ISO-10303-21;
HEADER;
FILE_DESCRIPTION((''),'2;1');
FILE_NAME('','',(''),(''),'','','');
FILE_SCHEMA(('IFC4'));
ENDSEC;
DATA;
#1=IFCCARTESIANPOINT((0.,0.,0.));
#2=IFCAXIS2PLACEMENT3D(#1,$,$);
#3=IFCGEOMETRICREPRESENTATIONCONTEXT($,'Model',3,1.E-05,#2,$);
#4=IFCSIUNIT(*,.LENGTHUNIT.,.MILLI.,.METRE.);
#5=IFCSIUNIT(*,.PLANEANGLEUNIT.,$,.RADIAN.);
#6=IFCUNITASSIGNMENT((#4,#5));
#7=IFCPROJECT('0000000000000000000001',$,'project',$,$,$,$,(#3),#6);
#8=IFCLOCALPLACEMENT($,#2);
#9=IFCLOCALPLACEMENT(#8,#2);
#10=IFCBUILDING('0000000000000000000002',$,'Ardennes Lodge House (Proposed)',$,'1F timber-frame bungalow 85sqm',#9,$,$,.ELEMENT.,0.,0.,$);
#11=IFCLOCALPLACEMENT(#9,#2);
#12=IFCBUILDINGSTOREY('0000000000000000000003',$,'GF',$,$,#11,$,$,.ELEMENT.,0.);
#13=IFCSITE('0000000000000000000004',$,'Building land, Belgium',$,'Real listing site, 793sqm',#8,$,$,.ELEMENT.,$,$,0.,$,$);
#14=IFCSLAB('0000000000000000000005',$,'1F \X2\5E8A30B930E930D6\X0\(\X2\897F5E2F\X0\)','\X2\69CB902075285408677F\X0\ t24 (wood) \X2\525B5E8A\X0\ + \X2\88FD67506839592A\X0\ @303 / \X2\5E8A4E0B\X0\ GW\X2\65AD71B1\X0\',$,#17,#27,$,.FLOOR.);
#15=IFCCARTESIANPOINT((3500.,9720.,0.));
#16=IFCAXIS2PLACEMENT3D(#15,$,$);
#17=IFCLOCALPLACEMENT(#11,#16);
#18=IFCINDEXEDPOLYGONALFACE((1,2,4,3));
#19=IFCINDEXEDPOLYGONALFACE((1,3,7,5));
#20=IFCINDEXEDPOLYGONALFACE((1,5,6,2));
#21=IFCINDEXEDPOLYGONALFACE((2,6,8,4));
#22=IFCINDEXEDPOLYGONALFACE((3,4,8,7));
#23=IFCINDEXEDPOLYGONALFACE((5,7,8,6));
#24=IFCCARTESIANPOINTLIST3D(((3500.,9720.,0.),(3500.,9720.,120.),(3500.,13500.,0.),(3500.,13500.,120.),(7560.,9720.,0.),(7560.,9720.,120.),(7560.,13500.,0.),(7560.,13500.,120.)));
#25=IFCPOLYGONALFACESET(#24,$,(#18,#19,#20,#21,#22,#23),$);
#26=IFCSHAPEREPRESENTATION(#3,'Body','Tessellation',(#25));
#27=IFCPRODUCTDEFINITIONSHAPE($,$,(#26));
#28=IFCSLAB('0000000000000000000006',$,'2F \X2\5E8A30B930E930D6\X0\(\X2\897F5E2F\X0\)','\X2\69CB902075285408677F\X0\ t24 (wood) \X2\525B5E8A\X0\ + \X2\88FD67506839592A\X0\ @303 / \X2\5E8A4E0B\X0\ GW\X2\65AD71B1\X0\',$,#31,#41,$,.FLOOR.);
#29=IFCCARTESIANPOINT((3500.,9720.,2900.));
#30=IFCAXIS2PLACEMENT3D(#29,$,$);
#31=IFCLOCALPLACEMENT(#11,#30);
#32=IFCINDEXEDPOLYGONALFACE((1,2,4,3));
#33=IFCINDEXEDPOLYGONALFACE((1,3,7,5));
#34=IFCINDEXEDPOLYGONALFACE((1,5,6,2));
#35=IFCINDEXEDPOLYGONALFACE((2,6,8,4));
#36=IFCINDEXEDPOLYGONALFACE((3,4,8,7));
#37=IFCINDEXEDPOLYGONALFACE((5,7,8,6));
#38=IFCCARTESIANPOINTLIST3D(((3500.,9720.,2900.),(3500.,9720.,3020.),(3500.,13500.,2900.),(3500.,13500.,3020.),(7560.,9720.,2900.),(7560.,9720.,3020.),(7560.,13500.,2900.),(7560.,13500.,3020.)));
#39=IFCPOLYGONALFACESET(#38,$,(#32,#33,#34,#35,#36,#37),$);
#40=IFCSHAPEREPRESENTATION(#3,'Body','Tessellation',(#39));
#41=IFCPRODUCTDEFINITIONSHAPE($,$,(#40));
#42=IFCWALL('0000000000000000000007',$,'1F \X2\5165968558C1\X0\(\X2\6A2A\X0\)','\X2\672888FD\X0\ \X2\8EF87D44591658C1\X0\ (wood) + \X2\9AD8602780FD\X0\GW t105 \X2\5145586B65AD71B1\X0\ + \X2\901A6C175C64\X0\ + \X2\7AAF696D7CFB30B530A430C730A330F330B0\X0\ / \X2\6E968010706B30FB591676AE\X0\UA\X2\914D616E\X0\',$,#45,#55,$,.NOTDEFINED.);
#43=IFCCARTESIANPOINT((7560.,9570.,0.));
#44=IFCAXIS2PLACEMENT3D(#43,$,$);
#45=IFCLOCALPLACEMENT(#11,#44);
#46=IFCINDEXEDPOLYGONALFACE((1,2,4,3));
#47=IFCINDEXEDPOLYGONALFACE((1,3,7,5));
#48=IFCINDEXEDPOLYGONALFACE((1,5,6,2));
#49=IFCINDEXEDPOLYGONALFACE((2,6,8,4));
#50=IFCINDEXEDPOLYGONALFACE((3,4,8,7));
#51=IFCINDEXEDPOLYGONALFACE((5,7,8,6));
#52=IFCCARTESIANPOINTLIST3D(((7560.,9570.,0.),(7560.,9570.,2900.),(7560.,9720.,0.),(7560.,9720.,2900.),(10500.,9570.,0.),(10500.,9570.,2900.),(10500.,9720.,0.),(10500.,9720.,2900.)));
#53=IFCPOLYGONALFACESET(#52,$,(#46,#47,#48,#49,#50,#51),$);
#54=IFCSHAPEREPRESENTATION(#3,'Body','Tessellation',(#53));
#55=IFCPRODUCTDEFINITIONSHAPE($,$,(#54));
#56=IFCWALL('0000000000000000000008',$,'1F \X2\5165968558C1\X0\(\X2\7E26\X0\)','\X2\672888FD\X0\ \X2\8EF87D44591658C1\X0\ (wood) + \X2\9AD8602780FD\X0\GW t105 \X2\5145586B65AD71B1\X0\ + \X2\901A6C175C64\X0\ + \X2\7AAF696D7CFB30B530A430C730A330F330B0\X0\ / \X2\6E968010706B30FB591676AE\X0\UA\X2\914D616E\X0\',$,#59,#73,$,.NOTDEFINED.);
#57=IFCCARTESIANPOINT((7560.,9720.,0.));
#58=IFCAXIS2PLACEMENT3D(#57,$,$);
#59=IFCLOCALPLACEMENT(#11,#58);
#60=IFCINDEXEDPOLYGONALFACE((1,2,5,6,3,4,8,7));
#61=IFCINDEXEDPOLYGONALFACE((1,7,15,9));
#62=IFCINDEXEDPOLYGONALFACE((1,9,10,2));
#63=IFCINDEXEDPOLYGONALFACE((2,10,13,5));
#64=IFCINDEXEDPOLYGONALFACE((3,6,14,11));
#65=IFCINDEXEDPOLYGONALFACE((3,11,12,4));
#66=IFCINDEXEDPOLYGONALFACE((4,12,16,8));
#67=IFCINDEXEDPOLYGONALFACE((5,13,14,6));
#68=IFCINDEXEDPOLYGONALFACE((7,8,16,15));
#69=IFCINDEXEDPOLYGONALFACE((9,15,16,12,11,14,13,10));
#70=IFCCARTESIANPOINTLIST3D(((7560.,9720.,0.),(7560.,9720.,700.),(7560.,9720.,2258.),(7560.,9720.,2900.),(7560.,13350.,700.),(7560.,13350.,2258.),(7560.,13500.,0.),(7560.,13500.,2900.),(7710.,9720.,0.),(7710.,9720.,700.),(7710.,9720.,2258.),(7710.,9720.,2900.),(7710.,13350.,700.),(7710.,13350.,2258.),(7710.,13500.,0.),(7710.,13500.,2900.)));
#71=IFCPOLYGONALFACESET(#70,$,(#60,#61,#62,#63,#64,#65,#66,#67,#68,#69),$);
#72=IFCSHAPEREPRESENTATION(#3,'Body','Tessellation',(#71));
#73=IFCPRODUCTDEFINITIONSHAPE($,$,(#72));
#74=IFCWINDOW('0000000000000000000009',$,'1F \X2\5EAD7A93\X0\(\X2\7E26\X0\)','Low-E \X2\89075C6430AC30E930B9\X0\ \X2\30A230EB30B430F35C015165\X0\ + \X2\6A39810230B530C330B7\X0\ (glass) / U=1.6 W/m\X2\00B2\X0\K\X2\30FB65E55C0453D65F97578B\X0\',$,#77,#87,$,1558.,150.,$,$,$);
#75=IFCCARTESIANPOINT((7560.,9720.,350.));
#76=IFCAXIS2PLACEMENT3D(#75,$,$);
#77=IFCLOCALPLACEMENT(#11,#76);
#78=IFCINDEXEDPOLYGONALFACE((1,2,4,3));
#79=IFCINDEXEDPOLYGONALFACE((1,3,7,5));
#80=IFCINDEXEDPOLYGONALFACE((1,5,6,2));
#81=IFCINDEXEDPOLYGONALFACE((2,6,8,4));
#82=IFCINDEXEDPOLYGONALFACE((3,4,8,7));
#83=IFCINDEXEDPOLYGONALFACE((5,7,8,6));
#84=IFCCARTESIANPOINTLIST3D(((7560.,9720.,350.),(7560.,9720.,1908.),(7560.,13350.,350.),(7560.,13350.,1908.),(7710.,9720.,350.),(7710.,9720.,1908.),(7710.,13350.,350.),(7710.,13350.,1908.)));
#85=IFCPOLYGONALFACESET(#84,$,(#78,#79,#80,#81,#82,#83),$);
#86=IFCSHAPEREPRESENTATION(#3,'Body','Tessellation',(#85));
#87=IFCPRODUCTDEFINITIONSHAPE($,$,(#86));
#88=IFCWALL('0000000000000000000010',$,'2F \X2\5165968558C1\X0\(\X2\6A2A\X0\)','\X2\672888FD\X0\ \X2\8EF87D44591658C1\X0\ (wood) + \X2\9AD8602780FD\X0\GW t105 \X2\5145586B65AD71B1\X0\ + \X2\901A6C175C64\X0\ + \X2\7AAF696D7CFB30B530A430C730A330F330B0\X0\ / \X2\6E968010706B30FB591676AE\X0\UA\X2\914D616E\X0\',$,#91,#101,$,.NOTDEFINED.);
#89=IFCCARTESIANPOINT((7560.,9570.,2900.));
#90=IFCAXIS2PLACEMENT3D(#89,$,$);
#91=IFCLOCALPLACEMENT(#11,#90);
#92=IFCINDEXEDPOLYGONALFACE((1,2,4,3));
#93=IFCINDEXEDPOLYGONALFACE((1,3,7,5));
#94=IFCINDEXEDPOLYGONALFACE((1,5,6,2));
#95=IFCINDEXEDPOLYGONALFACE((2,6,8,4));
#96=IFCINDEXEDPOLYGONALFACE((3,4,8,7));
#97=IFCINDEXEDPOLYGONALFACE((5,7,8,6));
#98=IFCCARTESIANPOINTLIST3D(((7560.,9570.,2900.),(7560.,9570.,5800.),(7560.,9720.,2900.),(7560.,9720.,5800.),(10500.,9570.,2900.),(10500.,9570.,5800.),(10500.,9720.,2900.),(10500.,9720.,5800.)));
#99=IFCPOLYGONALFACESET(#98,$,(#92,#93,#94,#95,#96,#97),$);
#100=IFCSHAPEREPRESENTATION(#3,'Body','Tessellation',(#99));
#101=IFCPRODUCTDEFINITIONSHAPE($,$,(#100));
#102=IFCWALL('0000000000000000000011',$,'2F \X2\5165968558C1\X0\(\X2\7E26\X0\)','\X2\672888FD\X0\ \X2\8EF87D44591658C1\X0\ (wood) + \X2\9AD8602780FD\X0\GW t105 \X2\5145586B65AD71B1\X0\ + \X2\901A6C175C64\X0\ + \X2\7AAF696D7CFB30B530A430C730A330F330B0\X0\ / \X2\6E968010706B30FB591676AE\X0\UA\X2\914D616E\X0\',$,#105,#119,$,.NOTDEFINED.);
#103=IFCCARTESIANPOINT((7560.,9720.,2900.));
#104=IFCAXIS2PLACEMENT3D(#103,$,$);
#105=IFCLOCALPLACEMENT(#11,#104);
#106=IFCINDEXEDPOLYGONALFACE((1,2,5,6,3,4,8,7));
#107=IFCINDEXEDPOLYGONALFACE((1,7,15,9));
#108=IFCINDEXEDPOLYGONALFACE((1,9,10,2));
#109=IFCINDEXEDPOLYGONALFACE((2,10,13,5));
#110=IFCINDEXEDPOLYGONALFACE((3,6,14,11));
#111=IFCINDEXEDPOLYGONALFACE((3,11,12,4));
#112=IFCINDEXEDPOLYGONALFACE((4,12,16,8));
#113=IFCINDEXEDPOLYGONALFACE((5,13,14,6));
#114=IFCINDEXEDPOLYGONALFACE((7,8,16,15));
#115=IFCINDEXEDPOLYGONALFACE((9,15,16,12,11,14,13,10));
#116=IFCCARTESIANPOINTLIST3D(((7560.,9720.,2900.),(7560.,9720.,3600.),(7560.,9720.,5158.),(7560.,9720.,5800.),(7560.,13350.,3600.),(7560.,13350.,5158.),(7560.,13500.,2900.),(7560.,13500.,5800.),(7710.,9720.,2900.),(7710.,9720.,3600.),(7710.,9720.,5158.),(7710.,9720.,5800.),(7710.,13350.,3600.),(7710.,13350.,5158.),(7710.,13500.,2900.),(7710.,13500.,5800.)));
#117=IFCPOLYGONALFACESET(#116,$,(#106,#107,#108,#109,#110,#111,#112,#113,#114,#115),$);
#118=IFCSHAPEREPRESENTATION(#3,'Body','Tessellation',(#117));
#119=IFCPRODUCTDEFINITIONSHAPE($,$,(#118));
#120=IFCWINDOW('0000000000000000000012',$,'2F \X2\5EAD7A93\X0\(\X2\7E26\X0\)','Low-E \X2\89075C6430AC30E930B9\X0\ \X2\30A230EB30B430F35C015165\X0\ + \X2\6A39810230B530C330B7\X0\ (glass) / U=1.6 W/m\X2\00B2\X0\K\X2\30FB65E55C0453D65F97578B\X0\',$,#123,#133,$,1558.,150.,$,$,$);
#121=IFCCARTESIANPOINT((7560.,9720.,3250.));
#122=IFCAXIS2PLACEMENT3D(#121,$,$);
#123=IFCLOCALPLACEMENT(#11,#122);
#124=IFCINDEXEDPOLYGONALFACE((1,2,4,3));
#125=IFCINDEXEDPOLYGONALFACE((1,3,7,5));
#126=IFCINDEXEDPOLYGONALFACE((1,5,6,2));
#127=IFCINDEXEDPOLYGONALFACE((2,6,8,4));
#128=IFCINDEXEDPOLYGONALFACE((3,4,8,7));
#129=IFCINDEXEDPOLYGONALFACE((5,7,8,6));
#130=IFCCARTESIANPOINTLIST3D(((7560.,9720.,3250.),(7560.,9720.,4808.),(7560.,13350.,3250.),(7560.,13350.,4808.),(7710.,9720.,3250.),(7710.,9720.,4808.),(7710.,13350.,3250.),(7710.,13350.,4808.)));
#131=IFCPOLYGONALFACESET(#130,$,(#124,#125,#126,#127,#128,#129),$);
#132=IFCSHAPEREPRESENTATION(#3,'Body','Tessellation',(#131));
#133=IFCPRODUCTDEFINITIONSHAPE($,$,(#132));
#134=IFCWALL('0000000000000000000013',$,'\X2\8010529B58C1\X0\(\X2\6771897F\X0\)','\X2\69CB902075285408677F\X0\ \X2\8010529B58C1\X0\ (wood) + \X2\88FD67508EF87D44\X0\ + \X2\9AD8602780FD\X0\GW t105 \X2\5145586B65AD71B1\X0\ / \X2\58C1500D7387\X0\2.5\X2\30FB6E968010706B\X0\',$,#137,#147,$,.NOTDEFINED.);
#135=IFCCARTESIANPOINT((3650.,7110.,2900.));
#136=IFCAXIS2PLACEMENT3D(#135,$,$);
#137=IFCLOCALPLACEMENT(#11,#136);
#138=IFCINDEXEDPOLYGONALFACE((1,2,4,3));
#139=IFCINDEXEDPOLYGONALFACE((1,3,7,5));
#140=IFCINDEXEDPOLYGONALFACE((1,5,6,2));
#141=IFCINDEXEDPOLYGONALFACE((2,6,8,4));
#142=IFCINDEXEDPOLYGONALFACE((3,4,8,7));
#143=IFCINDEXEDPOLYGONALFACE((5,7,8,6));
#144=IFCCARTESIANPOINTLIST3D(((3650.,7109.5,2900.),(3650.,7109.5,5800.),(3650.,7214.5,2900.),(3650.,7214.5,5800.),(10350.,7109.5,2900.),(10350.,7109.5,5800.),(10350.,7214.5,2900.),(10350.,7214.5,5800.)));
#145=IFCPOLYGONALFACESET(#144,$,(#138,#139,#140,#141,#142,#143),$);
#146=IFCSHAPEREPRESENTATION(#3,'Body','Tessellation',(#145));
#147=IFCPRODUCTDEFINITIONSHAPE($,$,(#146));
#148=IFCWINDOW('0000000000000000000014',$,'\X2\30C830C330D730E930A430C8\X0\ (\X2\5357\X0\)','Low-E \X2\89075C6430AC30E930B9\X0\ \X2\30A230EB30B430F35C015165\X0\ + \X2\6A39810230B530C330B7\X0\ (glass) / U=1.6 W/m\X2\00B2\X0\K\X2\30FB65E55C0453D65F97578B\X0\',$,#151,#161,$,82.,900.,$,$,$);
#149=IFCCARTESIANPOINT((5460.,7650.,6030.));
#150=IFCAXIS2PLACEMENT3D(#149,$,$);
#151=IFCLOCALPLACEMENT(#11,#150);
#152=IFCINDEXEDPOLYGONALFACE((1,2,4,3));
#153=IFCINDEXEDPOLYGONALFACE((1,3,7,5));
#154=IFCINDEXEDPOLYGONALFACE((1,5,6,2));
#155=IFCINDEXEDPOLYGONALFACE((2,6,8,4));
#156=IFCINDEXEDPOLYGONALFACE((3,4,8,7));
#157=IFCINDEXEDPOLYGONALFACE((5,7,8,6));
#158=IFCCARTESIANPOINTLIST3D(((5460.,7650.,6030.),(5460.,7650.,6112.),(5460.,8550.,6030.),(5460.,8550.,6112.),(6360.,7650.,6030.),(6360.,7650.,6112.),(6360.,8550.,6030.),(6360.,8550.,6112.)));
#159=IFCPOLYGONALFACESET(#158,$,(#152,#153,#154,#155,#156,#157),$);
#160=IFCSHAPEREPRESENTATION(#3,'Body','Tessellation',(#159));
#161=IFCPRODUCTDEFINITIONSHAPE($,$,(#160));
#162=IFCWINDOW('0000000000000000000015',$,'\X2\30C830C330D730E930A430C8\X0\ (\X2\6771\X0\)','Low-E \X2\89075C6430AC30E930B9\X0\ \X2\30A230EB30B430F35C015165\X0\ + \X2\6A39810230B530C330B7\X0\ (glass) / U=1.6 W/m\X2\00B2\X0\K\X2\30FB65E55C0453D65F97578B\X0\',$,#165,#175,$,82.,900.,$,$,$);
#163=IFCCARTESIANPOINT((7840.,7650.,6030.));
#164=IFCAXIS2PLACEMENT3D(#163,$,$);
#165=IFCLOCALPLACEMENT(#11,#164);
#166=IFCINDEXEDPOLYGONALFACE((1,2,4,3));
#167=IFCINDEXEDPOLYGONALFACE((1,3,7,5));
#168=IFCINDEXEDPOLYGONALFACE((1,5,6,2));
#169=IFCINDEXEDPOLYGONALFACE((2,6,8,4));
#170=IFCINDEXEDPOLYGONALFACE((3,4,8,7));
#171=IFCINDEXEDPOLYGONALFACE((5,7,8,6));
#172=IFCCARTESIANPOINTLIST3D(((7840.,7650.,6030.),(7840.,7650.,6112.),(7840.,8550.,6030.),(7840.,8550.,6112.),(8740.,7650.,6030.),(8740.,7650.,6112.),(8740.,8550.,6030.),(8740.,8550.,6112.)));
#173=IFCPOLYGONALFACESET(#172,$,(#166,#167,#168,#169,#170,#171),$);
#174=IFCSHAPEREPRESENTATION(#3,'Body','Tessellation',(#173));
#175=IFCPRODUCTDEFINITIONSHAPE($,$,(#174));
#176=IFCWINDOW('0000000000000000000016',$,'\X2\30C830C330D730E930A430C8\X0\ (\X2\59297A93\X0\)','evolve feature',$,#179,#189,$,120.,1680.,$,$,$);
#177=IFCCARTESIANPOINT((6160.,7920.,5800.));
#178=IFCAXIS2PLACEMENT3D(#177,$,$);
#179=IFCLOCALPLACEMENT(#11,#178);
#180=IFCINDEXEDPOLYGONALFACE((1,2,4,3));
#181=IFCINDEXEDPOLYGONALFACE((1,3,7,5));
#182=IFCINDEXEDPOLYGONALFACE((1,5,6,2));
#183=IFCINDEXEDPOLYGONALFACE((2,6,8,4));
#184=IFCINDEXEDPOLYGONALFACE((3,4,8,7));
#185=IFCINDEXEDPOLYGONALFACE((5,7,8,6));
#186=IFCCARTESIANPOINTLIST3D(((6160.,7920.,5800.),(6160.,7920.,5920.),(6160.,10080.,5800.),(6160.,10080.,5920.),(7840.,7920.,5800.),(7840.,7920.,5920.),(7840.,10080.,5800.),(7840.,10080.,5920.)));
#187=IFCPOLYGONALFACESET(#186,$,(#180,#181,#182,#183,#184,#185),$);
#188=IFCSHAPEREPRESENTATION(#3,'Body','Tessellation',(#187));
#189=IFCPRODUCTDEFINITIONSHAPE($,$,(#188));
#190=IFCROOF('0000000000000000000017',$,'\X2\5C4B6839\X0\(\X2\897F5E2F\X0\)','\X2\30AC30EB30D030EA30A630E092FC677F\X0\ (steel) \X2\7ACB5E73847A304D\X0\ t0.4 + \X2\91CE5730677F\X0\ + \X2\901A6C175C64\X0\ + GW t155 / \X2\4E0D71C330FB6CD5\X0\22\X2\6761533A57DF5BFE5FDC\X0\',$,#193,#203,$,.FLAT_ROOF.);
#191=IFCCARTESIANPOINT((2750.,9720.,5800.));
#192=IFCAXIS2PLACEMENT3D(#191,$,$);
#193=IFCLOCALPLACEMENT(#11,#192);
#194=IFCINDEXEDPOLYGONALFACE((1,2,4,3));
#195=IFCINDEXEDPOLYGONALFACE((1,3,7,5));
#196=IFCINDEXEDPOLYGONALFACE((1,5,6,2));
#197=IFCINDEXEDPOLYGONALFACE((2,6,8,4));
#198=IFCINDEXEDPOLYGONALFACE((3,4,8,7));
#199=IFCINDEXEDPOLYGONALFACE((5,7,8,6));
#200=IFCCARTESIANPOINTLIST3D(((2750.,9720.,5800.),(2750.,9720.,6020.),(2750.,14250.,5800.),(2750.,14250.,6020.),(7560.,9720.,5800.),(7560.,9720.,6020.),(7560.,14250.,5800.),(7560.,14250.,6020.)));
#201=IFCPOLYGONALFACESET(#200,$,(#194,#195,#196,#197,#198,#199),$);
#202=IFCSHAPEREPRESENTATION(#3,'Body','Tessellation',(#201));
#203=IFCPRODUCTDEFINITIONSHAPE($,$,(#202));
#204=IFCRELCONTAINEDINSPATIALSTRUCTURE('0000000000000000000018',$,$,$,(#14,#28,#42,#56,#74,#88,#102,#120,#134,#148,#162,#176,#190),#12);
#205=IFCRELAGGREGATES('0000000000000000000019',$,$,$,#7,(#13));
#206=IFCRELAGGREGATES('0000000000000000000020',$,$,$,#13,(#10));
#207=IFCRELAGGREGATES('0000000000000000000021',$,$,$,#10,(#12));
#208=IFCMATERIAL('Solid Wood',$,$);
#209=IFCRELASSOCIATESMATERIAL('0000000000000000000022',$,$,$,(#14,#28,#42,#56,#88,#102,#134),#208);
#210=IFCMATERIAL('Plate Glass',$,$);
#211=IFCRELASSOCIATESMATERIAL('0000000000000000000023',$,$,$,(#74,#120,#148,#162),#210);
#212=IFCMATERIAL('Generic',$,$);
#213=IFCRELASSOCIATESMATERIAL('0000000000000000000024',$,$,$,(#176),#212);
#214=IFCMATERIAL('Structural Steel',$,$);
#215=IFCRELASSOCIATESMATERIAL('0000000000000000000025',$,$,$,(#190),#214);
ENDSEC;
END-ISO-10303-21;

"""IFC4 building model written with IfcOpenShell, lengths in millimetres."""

from ifc_helpers import new_model, si_unit, frame, frame_2d, origin, place, context, project, spatial, rectangle, extrude, material, element, fill, save


model = new_model("IFC4")

# Units and contexts
model_context = context("Model", 3, precision=1e-05, world=origin())
ifc_project = project(units=[si_unit("LENGTHUNIT", "METRE", prefix="MILLI"), si_unit("PLANEANGLEUNIT", "RADIAN")], contexts=[model_context])

# Site, building, storey
site_placement = place(None, origin())
site = spatial("IfcSite", under=ifc_project, at=site_placement, Name="Building land, Belgium", ObjectType="Real listing site, 793sqm", CompositionType="ELEMENT", RefElevation=0.0)
building_placement = place(site_placement, origin())
building = spatial("IfcBuilding", under=site, at=building_placement, Name="Ardennes Lodge House (Proposed)", ObjectType="1F timber-frame bungalow 85sqm", CompositionType="ELEMENT", ElevationOfRefHeight=0.0, ElevationOfTerrain=0.0)
storey_placement = place(building_placement, origin())
storey = spatial("IfcBuildingStorey", under=building, at=storey_placement, Name="GF", CompositionType="ELEMENT", Elevation=0.0)

# Slabs
ifc_material_1 = material(Name="Solid Wood")
slab_1_placement = place(storey_placement, frame((3500.0, 9720.0, 0.0)))
element("IfcSlab", 1, at=slab_1_placement, inside=storey, material=ifc_material_1, Name="1F 床スラブ(西帯)", Description="構造用合板 t24 (wood) 剛床 + 製材根太 @303 / 床下 GW断熱", PredefinedType="FLOOR", context=model_context, shape_type="SweptSolid", body=[
    extrude(rectangle(XDim=4060.0, YDim=3780.0, at=frame_2d((2030.0, 1890.0))), frame((3500.0, 9720.0, 0.0)), (0.0, 0.0, 1.0), 120.0),
])
slab_2_placement = place(storey_placement, frame((3500.0, 9720.0, 2900.0)))
element("IfcSlab", 2, at=slab_2_placement, inside=storey, material=ifc_material_1, Name="2F 床スラブ(西帯)", Description="構造用合板 t24 (wood) 剛床 + 製材根太 @303 / 床下 GW断熱", PredefinedType="FLOOR", context=model_context, shape_type="SweptSolid", body=[
    extrude(rectangle(XDim=4060.0, YDim=3780.0, at=frame_2d((2030.0, 1890.0))), frame((3500.0, 9720.0, 2900.0)), (0.0, 0.0, 1.0), 120.0),
])

# Wall
wall_1_placement = place(storey_placement, frame((7560.0, 9570.0, 0.0)))
element("IfcWall", 3, at=wall_1_placement, inside=storey, material=ifc_material_1, Name="1F 入隅壁(横)", Description="木製 軸組外壁 (wood) + 高性能GW t105 充填断熱 + 通気層 + 窯業系サイディング / 準耐火・外皮UA配慮", PredefinedType="NOTDEFINED", context=model_context, shape_type="SweptSolid", body=[
    extrude(rectangle(XDim=2940.0, YDim=150.0, at=frame_2d((1470.0, 75.0))), frame((7560.0, 9570.0, 0.0)), (0.0, 0.0, 1.0), 2900.0),
])

# Wall, opening, window
wall_2_placement = place(storey_placement, frame((7560.0, 9720.0, 0.0)))
wall_2 = element("IfcWall", 4, at=wall_2_placement, inside=storey, material=ifc_material_1, Name="1F 入隅壁(縦)", Description="木製 軸組外壁 (wood) + 高性能GW t105 充填断熱 + 通気層 + 窯業系サイディング / 準耐火・外皮UA配慮", PredefinedType="NOTDEFINED", context=model_context, shape_type="SweptSolid", body=[
    extrude(rectangle(XDim=150.0, YDim=3780.0, at=frame_2d((75.0, 1890.0))), frame((7560.0, 9720.0, 0.0)), (0.0, 0.0, 1.0), 2900.0),
])
opening_1_placement = place(storey_placement, frame((7560.0, 9720.0, 350.0)))
opening_1 = element("IfcOpeningElement", 5, at=opening_1_placement, cuts=wall_2, PredefinedType="NOTDEFINED", context=model_context, shape_type="SweptSolid", body=[
    extrude(rectangle(XDim=150.0, YDim=3630.0, at=frame_2d((75.0, 1815.0))), frame((7560.0, 9720.0, 350.0)), (0.0, 0.0, 1.0), 1558.0),
])
ifc_material_2 = material(Name="Plate Glass")
window_1_placement = place(storey_placement, frame((7560.0, 9720.0, 350.0)))
window_1 = element("IfcWindow", 6, at=window_1_placement, inside=storey, material=ifc_material_2, Name="1F 庭窓(縦)", Description="Low-E 複層ガラス アルゴン封入 + 樹脂サッシ (glass) / U=1.6 W/m²K・日射取得型", OverallHeight=1558.0, OverallWidth=150.0, context=model_context, shape_type="SweptSolid", body=[
    extrude(rectangle(XDim=150.0, YDim=3630.0, at=frame_2d((75.0, 1815.0))), frame((7560.0, 9720.0, 350.0)), (0.0, 0.0, 1.0), 1558.0),
])
fill(opening_1, window_1)

# Wall
wall_3_placement = place(storey_placement, frame((7560.0, 9570.0, 2900.0)))
element("IfcWall", 7, at=wall_3_placement, inside=storey, material=ifc_material_1, Name="2F 入隅壁(横)", Description="木製 軸組外壁 (wood) + 高性能GW t105 充填断熱 + 通気層 + 窯業系サイディング / 準耐火・外皮UA配慮", PredefinedType="NOTDEFINED", context=model_context, shape_type="SweptSolid", body=[
    extrude(rectangle(XDim=2940.0, YDim=150.0, at=frame_2d((1470.0, 75.0))), frame((7560.0, 9570.0, 2900.0)), (0.0, 0.0, 1.0), 2900.0),
])

# Wall, opening, window
wall_4_placement = place(storey_placement, frame((7560.0, 9720.0, 2900.0)))
wall_4 = element("IfcWall", 8, at=wall_4_placement, inside=storey, material=ifc_material_1, Name="2F 入隅壁(縦)", Description="木製 軸組外壁 (wood) + 高性能GW t105 充填断熱 + 通気層 + 窯業系サイディング / 準耐火・外皮UA配慮", PredefinedType="NOTDEFINED", context=model_context, shape_type="SweptSolid", body=[
    extrude(rectangle(XDim=150.0, YDim=3780.0, at=frame_2d((75.0, 1890.0))), frame((7560.0, 9720.0, 2900.0)), (0.0, 0.0, 1.0), 2900.0),
])
opening_2_placement = place(storey_placement, frame((7560.0, 9720.0, 3250.0)))
opening_2 = element("IfcOpeningElement", 9, at=opening_2_placement, cuts=wall_4, PredefinedType="NOTDEFINED", context=model_context, shape_type="SweptSolid", body=[
    extrude(rectangle(XDim=150.0, YDim=3630.0, at=frame_2d((75.0, 1815.0))), frame((7560.0, 9720.0, 3250.0)), (0.0, 0.0, 1.0), 1558.0),
])
window_2_placement = place(storey_placement, frame((7560.0, 9720.0, 3250.0)))
window_2 = element("IfcWindow", 10, at=window_2_placement, inside=storey, material=ifc_material_2, Name="2F 庭窓(縦)", Description="Low-E 複層ガラス アルゴン封入 + 樹脂サッシ (glass) / U=1.6 W/m²K・日射取得型", OverallHeight=1558.0, OverallWidth=150.0, context=model_context, shape_type="SweptSolid", body=[
    extrude(rectangle(XDim=150.0, YDim=3630.0, at=frame_2d((75.0, 1815.0))), frame((7560.0, 9720.0, 3250.0)), (0.0, 0.0, 1.0), 1558.0),
])
fill(opening_2, window_2)

# Wall
wall_5_placement = place(storey_placement, frame((3650.0, 7110.0, 2900.0)))
element("IfcWall", 11, at=wall_5_placement, inside=storey, material=ifc_material_1, Name="耐力壁(東西)", Description="構造用合板 耐力壁 (wood) + 製材軸組 + 高性能GW t105 充填断熱 / 壁倍率2.5・準耐火", PredefinedType="NOTDEFINED", context=model_context, shape_type="SweptSolid", body=[
    extrude(rectangle(XDim=6700.0, YDim=105.0, at=frame_2d((3350.0, 52.0))), frame((3650.0, 7110.0, 2900.0)), (0.0, 0.0, 1.0), 2900.0),
])

# Windows
window_3_placement = place(storey_placement, frame((5460.0, 7650.0, 6030.0)))
element("IfcWindow", 12, at=window_3_placement, inside=storey, material=ifc_material_2, Name="トップライト (南)", Description="Low-E 複層ガラス アルゴン封入 + 樹脂サッシ (glass) / U=1.6 W/m²K・日射取得型", OverallHeight=82.0, OverallWidth=900.0, context=model_context, shape_type="SweptSolid", body=[
    extrude(rectangle(XDim=900.0, YDim=900.0, at=frame_2d((450.0, 450.0))), frame((5460.0, 7650.0, 6030.0)), (0.0, 0.0, 1.0), 82.0),
])
window_4_placement = place(storey_placement, frame((7840.0, 7650.0, 6030.0)))
element("IfcWindow", 13, at=window_4_placement, inside=storey, material=ifc_material_2, Name="トップライト (東)", Description="Low-E 複層ガラス アルゴン封入 + 樹脂サッシ (glass) / U=1.6 W/m²K・日射取得型", OverallHeight=82.0, OverallWidth=900.0, context=model_context, shape_type="SweptSolid", body=[
    extrude(rectangle(XDim=900.0, YDim=900.0, at=frame_2d((450.0, 450.0))), frame((7840.0, 7650.0, 6030.0)), (0.0, 0.0, 1.0), 82.0),
])
ifc_material_3 = material(Name="Generic")
window_5_placement = place(storey_placement, frame((6160.0, 7920.0, 5800.0)))
element("IfcWindow", 14, at=window_5_placement, inside=storey, material=ifc_material_3, Name="トップライト (天窓)", Description="evolve feature", OverallHeight=120.0, OverallWidth=1680.0, context=model_context, shape_type="SweptSolid", body=[
    extrude(rectangle(XDim=1680.0, YDim=2160.0, at=frame_2d((840.0, 1080.0))), frame((6160.0, 7920.0, 5800.0)), (0.0, 0.0, 1.0), 120.0),
])

# Roof
ifc_material_4 = material(Name="Structural Steel")
for number, where, name in (
    (15, (2750.0, 9720.0, 5800.0), "屋根(西帯)"),
):
    element("IfcRoof", number, at=place(storey_placement, frame(where)), inside=storey, material=ifc_material_4, Name=name, Description="ガルバリウム鋼板 (steel) 立平葺き t0.4 + 野地板 + 通気層 + GW t155 / 不燃・法22条区域対応", PredefinedType="FLAT_ROOF", context=model_context, shape_type="SweptSolid", body=[
        extrude(rectangle(XDim=4810.0, YDim=4530.0, at=frame_2d((2405.0, 2265.0))), frame((2750.0, 9720.0, 5800.0)), (0.0, 0.0, 1.0), 220.0),
    ])

save(model, "model.ifc")
